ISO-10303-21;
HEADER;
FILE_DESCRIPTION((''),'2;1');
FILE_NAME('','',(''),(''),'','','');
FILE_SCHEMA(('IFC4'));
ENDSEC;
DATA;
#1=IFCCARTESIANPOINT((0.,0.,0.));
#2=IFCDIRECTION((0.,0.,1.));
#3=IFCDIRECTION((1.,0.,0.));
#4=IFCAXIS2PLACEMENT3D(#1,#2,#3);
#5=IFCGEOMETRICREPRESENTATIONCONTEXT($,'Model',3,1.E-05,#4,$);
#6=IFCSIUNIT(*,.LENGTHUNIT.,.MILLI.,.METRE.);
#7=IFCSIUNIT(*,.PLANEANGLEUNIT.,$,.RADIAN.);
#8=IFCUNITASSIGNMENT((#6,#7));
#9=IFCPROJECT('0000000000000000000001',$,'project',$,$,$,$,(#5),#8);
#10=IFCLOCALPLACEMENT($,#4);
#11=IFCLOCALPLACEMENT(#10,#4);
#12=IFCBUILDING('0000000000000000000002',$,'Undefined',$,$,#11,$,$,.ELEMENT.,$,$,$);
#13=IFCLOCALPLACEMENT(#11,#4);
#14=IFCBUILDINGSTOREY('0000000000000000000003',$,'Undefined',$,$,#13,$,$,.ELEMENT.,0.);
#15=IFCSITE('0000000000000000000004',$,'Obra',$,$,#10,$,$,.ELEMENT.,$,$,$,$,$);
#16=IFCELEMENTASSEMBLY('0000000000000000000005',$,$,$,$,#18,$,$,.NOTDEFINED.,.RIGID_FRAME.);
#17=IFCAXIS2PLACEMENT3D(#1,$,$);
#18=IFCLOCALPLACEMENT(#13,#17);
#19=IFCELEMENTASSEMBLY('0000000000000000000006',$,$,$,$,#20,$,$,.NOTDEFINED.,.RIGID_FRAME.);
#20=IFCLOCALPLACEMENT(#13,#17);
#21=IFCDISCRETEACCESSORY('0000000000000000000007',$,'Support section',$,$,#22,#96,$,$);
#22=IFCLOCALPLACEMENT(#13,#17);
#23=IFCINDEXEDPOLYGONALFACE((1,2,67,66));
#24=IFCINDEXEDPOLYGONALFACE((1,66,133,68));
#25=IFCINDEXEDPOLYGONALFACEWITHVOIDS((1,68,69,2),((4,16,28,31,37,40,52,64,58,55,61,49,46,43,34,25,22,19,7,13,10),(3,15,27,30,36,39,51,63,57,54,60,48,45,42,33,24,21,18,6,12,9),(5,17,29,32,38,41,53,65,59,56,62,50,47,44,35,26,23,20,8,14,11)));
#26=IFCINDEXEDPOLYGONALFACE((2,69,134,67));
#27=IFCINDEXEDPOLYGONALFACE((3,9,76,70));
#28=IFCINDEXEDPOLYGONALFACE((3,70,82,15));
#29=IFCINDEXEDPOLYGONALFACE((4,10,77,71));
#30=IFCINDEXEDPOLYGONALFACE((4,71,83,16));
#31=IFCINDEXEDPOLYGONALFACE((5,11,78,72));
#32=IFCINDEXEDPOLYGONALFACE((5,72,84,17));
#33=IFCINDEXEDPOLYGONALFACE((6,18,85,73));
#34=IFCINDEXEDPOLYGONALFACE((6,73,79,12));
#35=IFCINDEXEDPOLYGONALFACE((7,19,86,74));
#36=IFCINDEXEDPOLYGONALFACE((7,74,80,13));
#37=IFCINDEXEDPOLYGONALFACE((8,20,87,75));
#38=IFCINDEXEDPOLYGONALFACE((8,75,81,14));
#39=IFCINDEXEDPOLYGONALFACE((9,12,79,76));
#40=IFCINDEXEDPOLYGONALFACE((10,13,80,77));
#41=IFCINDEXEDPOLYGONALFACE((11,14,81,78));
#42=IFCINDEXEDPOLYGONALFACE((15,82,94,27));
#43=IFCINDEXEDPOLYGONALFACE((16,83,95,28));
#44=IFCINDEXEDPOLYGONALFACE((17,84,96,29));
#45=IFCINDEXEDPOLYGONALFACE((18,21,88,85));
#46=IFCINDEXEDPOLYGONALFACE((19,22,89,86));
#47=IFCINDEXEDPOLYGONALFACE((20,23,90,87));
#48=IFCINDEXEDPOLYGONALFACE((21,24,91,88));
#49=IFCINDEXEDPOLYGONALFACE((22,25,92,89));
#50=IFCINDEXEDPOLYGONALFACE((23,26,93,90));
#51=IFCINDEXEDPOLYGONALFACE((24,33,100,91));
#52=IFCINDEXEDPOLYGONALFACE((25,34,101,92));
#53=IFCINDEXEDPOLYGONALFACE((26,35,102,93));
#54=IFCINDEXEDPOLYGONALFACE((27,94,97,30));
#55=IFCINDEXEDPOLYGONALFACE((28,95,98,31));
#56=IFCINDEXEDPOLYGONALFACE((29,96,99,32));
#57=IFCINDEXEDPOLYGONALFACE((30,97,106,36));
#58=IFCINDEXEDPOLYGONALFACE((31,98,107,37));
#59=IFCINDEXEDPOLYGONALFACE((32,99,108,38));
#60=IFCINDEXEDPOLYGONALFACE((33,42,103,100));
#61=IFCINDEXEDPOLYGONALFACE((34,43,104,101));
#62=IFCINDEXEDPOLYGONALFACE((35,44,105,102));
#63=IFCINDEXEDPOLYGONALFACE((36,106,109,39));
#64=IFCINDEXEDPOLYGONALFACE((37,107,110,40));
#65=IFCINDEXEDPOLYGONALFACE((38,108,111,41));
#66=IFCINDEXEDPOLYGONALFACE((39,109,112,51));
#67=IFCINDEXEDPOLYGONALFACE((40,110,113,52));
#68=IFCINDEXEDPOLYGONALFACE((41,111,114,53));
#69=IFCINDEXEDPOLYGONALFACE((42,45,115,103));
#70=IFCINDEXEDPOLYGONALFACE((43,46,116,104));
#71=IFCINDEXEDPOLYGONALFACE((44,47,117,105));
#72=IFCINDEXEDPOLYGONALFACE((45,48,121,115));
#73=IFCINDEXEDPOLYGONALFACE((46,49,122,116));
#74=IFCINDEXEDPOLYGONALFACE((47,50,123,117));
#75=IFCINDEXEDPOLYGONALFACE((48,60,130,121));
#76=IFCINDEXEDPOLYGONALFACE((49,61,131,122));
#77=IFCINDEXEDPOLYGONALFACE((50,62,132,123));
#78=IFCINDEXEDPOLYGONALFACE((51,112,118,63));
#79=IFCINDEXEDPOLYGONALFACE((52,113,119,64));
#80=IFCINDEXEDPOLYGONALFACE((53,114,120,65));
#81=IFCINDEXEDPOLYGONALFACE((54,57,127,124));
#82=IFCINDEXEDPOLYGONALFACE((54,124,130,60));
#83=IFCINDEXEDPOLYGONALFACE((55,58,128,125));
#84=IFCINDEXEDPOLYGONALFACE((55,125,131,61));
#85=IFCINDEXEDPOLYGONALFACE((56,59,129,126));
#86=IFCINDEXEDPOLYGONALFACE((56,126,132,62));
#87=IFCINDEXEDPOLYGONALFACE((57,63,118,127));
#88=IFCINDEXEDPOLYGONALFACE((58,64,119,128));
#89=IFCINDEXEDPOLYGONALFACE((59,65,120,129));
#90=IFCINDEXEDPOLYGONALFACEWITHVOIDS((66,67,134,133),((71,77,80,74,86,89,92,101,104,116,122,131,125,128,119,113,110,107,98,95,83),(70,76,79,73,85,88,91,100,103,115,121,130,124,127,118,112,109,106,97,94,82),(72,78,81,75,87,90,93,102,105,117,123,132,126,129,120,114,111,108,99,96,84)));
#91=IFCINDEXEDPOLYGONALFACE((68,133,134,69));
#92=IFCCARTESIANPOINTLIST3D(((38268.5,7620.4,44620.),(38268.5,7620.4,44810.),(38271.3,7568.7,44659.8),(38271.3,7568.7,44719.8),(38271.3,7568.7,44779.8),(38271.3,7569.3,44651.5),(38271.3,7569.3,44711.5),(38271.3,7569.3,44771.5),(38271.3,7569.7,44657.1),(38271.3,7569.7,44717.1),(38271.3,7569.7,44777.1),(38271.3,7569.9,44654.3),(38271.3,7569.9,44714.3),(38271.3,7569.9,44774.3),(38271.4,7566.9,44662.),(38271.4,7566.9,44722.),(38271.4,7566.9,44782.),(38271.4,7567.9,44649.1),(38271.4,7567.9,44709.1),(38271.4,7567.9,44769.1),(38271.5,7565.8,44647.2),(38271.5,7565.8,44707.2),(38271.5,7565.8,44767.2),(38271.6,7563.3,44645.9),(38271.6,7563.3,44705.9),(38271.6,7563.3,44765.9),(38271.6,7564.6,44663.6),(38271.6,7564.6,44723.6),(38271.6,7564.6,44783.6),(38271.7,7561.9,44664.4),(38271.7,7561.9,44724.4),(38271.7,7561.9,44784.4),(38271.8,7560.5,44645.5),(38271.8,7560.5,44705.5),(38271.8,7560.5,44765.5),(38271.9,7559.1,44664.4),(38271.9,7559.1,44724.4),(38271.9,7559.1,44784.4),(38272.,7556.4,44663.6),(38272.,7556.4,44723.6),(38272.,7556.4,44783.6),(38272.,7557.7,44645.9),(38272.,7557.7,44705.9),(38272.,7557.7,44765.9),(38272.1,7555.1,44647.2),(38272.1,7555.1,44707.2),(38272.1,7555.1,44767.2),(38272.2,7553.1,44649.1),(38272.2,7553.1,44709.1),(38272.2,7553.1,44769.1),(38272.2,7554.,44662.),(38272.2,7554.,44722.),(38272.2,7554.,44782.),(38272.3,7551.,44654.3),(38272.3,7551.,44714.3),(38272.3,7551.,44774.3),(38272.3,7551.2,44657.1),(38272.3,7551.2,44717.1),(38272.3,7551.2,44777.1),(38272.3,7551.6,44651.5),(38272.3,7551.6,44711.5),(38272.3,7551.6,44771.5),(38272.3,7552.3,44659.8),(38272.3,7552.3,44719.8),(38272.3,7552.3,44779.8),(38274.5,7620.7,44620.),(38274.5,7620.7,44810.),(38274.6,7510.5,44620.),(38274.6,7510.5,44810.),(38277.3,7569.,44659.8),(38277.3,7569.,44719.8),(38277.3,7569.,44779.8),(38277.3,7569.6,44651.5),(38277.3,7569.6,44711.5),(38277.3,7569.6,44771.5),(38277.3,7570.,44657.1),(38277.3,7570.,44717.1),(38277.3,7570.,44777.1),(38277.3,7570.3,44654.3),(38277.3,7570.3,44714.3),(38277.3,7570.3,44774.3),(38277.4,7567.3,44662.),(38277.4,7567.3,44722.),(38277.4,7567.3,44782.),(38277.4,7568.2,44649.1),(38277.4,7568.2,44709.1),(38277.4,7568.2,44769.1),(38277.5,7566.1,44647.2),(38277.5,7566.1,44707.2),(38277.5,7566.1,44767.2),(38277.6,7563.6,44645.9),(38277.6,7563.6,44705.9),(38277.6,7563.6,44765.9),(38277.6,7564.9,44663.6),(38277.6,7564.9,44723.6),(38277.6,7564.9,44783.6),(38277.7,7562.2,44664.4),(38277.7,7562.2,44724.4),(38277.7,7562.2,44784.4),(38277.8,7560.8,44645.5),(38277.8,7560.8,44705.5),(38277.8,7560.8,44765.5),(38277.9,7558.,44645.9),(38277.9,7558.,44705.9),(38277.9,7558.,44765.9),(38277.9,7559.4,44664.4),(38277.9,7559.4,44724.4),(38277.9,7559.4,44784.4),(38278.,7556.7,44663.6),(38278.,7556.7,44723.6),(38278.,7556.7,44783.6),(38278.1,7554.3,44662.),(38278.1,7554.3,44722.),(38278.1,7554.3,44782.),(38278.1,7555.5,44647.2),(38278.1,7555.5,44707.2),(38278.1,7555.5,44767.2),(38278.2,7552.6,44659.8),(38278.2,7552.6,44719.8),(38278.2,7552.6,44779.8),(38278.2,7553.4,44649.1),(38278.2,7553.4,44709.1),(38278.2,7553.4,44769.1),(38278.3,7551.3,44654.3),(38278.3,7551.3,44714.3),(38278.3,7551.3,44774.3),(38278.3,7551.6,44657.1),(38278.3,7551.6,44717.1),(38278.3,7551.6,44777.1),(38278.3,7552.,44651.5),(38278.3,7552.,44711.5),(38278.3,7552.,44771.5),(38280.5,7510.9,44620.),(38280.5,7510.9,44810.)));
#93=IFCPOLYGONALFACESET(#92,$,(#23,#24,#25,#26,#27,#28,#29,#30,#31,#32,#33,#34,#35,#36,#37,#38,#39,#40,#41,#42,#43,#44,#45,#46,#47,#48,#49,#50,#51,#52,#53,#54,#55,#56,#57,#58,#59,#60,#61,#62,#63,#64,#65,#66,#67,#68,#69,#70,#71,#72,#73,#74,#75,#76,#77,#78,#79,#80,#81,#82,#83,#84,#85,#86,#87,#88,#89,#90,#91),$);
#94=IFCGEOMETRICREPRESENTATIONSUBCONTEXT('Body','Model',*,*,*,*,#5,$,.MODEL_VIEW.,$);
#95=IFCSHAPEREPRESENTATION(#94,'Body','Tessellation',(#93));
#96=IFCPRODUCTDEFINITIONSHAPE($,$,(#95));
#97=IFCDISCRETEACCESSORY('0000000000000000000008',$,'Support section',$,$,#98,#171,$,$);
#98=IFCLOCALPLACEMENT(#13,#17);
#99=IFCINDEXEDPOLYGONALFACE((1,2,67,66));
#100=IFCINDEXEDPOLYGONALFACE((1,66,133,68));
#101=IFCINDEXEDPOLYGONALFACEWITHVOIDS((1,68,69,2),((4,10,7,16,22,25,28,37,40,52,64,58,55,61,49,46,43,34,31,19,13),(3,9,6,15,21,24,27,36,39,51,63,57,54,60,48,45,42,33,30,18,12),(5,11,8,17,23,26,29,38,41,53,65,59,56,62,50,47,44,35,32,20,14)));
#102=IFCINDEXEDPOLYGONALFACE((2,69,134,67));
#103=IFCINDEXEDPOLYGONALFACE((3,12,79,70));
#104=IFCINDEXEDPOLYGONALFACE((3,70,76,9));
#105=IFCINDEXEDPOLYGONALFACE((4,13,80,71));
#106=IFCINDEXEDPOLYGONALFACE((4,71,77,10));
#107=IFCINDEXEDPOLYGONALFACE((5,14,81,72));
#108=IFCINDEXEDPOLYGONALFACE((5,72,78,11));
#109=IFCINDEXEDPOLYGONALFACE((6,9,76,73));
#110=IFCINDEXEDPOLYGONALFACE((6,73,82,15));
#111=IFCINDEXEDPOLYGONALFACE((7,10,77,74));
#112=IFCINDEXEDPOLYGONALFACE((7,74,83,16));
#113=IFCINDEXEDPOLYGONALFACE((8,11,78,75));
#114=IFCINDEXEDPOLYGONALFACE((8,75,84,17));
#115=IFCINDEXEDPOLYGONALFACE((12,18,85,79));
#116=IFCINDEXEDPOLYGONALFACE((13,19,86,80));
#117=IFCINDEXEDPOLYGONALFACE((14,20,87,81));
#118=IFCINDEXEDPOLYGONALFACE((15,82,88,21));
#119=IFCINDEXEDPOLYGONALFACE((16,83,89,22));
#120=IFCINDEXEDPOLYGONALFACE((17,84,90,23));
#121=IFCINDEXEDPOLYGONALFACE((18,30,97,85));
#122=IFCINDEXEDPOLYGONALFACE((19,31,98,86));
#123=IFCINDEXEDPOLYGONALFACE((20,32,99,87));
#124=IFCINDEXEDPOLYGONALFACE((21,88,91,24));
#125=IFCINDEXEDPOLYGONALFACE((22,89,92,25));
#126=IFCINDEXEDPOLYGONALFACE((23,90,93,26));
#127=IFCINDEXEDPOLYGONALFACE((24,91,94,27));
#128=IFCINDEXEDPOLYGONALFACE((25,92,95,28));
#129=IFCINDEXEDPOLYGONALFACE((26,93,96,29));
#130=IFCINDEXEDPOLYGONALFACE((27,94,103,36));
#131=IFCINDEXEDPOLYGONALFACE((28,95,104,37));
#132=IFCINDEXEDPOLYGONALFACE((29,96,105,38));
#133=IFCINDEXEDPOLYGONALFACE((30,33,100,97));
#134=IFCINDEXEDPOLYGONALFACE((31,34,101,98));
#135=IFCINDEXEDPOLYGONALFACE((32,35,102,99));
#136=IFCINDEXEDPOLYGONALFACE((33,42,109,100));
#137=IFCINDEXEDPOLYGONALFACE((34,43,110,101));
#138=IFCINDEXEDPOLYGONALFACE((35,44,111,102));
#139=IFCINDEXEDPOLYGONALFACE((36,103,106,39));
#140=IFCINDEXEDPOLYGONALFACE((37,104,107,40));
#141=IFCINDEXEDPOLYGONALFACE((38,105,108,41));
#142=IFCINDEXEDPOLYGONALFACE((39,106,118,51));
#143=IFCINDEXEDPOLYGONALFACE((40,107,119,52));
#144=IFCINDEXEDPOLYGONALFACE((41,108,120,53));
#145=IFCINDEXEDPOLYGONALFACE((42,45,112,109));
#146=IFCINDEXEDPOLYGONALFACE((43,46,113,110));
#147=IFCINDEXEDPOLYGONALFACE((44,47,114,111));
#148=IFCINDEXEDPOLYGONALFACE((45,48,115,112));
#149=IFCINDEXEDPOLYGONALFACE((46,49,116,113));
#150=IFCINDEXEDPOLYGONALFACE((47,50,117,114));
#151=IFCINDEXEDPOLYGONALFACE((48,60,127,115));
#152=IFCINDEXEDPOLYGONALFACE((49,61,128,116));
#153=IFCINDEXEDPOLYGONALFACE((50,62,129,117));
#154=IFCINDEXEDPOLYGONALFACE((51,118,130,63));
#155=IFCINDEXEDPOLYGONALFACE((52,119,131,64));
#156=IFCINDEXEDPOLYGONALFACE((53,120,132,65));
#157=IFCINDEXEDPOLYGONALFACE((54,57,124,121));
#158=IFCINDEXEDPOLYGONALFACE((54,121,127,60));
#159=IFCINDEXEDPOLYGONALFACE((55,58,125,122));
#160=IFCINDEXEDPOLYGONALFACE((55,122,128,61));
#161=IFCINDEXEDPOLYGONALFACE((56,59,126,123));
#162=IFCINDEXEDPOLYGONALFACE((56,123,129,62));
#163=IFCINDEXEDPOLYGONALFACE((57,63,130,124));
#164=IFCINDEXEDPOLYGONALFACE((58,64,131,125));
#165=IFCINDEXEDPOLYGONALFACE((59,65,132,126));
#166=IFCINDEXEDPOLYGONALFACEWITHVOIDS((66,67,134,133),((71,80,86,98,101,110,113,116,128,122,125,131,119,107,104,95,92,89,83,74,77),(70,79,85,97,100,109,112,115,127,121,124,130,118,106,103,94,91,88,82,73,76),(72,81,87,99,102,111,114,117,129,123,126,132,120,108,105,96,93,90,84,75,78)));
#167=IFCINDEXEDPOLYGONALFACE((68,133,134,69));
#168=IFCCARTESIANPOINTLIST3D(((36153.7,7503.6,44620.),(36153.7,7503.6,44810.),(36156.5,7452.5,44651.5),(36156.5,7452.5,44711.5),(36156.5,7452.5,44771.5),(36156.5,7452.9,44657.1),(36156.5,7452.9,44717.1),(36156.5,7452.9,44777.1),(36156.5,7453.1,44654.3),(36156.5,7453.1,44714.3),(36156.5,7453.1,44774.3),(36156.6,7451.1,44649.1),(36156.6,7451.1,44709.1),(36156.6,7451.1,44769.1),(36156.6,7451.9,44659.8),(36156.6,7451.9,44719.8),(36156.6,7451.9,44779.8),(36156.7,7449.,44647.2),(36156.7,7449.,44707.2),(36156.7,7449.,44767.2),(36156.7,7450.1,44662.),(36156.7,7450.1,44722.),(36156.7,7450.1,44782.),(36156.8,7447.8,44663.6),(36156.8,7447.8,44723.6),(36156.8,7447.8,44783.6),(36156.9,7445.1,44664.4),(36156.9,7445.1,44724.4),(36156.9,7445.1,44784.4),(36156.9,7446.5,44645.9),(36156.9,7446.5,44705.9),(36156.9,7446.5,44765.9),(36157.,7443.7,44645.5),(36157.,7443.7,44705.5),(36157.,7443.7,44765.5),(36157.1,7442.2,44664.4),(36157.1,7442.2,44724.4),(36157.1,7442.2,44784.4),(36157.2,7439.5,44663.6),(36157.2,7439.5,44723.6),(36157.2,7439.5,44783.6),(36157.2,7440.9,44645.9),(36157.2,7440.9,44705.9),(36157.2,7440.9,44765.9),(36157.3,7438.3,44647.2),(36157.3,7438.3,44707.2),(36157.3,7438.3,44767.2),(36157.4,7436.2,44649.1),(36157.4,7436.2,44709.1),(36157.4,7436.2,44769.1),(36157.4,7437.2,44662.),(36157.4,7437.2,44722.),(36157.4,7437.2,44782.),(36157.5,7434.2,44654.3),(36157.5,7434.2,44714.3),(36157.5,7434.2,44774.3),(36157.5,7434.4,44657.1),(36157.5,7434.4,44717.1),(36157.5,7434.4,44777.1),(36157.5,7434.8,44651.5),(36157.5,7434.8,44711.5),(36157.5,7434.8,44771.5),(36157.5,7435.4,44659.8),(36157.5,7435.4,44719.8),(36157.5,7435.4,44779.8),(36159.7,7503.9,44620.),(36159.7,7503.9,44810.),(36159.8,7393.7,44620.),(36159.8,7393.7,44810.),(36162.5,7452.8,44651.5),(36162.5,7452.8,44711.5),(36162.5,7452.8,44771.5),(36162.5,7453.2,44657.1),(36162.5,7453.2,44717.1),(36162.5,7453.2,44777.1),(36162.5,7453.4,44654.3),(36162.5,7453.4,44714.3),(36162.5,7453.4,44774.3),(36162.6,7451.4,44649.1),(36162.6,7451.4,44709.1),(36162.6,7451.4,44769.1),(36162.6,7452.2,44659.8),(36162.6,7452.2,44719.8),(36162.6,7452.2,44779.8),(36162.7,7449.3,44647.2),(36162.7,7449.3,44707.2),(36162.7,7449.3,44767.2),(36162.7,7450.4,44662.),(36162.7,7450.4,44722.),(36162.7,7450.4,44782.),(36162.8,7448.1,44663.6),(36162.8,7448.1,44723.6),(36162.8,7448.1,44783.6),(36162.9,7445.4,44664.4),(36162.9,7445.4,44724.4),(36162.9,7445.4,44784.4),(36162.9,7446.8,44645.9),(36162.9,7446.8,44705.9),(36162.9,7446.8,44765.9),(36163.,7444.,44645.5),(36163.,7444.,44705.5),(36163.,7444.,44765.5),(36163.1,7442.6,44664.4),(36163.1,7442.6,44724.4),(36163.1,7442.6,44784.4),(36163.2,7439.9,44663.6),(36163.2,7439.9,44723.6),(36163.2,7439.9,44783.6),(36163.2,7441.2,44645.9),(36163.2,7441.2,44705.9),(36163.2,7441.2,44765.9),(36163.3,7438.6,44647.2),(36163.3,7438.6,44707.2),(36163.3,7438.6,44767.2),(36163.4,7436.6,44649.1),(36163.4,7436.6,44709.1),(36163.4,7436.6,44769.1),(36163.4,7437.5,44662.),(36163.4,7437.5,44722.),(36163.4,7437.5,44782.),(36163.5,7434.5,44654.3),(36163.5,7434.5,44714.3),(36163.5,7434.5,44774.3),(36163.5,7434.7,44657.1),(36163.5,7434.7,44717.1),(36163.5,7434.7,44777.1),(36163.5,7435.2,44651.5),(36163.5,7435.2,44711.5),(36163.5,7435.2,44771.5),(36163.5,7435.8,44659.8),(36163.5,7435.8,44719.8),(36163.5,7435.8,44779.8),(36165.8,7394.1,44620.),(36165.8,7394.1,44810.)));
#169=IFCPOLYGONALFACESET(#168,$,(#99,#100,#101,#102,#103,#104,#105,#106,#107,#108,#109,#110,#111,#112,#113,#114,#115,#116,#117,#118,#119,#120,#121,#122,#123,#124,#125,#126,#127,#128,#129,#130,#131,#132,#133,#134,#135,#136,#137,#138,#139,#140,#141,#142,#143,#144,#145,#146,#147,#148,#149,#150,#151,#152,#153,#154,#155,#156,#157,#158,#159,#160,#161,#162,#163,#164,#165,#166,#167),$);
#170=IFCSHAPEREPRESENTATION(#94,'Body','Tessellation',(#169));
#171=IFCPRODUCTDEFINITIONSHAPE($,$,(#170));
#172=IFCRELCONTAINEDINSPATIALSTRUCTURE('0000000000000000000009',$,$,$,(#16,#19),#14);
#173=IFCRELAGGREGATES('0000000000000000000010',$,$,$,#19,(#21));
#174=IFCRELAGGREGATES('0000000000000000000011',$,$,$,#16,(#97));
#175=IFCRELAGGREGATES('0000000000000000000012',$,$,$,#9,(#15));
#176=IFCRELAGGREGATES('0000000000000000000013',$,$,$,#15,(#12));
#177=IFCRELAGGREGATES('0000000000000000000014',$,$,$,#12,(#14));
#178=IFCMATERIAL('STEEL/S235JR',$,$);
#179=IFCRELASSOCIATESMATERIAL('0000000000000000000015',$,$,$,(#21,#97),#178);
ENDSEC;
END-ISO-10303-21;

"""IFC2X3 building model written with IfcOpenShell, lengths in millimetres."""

from ifc_helpers import new_model, si_unit, frame, origin_with_axes, origin_2d_with_axis, place, context, subcontext, project, spatial, rectangle, circle, extrude, source, transform, mapped, material, element, aggregate, save


model = new_model("IFC2X3")

# Units and contexts
model_context = context("Model", 3, precision=1e-05, world=origin_with_axes())
body_context = subcontext(model_context, "Body", "Model", "MODEL_VIEW")
ifc_project = project(units=[si_unit("LENGTHUNIT", "METRE", prefix="MILLI"), si_unit("PLANEANGLEUNIT", "RADIAN")], contexts=[model_context])

# Site, building, storey
site_placement = place(None, origin_with_axes())
site = spatial("IfcSite", under=ifc_project, at=site_placement, Name="Obra", CompositionType="ELEMENT")
building_placement = place(site_placement, origin_with_axes())
building = spatial("IfcBuilding", under=site, at=building_placement, Name="Undefined", CompositionType="ELEMENT")
storey_placement = place(building_placement, origin_with_axes())
storey = spatial("IfcBuildingStorey", under=building, at=storey_placement, Name="Undefined", CompositionType="ELEMENT", Elevation=0.0)

# Element assembly
assembly_1_placement = place(storey_placement, origin_with_axes())
assembly_1 = element("IfcElementAssembly", 1, at=assembly_1_placement, inside=storey, AssemblyPlace="NOTDEFINED", PredefinedType="RIGID_FRAME")
ifc_material_1 = material(Name="STEEL/S235JR")

# Element assembly, discrete accessory, opening
assembly_2_placement = place(storey_placement, origin_with_axes())
assembly_2 = element("IfcElementAssembly", 2, at=assembly_2_placement, inside=storey, AssemblyPlace="NOTDEFINED", PredefinedType="RIGID_FRAME")
discrete_accessory_1_placement = place(assembly_2_placement, frame((38274.5, 7565.6, 44620.0), z_axis=(0.0, 0.0, 1.0), x_axis=(-0.055152, 0.998478, 0.0)))
discrete_accessory_1 = element("IfcDiscreteAccessory", 3, at=discrete_accessory_1_placement, material=ifc_material_1, Name="Support section", context=body_context, shape_type="SweptSolid", body=[
    extrude(rectangle(XDim=6.0, YDim=110.0, at=origin_2d_with_axis()), frame((0.0, 0.0, 190.0), z_axis=(0.0, 0.0, -1.0), x_axis=(0.0, 1.0, 0.0)), (0.0, 0.0, 1.0), 190.0),
])
shared_shape_1 = source(origin_with_axes(), body_context, "Body", "SweptSolid", [
    extrude(circle(Radius=9.5, at=origin_2d_with_axis()), frame((0.0, -9.2, 0.0), z_axis=(0.0, 1.0, 0.0), x_axis=(1.0, 0.0, 0.0)), (0.0, 0.0, 1.0), 6.2),
])
opening_1_placement = place(assembly_2_placement, frame((38278.1, 7610.9, 44835.0), z_axis=(0.055152, -0.998478, 0.0), x_axis=(0.0, 0.0, -1.0)))
element("IfcOpeningElement", 4, at=opening_1_placement, cuts=discrete_accessory_1, ObjectType="Opening", context=body_context, shape_type="MappedRepresentation", body=[
    mapped(shared_shape_1, transform((60.0, 0.0, 50.0))),
    mapped(shared_shape_1, transform((120.0, 0.0, 50.0))),
    mapped(shared_shape_1, transform((180.0, 0.0, 50.0))),
])
aggregate(assembly_2, [discrete_accessory_1])

# Discrete accessory, opening
discrete_accessory_2_placement = place(assembly_1_placement, frame((36159.7, 7448.8, 44620.0), z_axis=(0.0, 0.0, 1.0), x_axis=(-0.055152, 0.998478, 0.0)))
discrete_accessory_2 = element("IfcDiscreteAccessory", 5, at=discrete_accessory_2_placement, material=ifc_material_1, Name="Support section", context=body_context, shape_type="SweptSolid", body=[
    extrude(rectangle(XDim=6.0, YDim=110.0, at=origin_2d_with_axis()), frame((0.0, 0.0, 190.0), z_axis=(0.0, 0.0, -1.0), x_axis=(0.0, 1.0, 0.0)), (0.0, 0.0, 1.0), 190.0),
])
opening_2_placement = place(assembly_1_placement, frame((36163.3, 7494.1, 44835.0), z_axis=(0.055152, -0.998478, 0.0), x_axis=(0.0, 0.0, -1.0)))
element("IfcOpeningElement", 6, at=opening_2_placement, cuts=discrete_accessory_2, ObjectType="Opening", context=body_context, shape_type="MappedRepresentation", body=[
    mapped(shared_shape_1, transform((60.0, 0.0, 50.0))),
    mapped(shared_shape_1, transform((120.0, 0.0, 50.0))),
    mapped(shared_shape_1, transform((180.0, 0.0, 50.0))),
])
aggregate(assembly_1, [discrete_accessory_2])

save(model, "model.ifc")
